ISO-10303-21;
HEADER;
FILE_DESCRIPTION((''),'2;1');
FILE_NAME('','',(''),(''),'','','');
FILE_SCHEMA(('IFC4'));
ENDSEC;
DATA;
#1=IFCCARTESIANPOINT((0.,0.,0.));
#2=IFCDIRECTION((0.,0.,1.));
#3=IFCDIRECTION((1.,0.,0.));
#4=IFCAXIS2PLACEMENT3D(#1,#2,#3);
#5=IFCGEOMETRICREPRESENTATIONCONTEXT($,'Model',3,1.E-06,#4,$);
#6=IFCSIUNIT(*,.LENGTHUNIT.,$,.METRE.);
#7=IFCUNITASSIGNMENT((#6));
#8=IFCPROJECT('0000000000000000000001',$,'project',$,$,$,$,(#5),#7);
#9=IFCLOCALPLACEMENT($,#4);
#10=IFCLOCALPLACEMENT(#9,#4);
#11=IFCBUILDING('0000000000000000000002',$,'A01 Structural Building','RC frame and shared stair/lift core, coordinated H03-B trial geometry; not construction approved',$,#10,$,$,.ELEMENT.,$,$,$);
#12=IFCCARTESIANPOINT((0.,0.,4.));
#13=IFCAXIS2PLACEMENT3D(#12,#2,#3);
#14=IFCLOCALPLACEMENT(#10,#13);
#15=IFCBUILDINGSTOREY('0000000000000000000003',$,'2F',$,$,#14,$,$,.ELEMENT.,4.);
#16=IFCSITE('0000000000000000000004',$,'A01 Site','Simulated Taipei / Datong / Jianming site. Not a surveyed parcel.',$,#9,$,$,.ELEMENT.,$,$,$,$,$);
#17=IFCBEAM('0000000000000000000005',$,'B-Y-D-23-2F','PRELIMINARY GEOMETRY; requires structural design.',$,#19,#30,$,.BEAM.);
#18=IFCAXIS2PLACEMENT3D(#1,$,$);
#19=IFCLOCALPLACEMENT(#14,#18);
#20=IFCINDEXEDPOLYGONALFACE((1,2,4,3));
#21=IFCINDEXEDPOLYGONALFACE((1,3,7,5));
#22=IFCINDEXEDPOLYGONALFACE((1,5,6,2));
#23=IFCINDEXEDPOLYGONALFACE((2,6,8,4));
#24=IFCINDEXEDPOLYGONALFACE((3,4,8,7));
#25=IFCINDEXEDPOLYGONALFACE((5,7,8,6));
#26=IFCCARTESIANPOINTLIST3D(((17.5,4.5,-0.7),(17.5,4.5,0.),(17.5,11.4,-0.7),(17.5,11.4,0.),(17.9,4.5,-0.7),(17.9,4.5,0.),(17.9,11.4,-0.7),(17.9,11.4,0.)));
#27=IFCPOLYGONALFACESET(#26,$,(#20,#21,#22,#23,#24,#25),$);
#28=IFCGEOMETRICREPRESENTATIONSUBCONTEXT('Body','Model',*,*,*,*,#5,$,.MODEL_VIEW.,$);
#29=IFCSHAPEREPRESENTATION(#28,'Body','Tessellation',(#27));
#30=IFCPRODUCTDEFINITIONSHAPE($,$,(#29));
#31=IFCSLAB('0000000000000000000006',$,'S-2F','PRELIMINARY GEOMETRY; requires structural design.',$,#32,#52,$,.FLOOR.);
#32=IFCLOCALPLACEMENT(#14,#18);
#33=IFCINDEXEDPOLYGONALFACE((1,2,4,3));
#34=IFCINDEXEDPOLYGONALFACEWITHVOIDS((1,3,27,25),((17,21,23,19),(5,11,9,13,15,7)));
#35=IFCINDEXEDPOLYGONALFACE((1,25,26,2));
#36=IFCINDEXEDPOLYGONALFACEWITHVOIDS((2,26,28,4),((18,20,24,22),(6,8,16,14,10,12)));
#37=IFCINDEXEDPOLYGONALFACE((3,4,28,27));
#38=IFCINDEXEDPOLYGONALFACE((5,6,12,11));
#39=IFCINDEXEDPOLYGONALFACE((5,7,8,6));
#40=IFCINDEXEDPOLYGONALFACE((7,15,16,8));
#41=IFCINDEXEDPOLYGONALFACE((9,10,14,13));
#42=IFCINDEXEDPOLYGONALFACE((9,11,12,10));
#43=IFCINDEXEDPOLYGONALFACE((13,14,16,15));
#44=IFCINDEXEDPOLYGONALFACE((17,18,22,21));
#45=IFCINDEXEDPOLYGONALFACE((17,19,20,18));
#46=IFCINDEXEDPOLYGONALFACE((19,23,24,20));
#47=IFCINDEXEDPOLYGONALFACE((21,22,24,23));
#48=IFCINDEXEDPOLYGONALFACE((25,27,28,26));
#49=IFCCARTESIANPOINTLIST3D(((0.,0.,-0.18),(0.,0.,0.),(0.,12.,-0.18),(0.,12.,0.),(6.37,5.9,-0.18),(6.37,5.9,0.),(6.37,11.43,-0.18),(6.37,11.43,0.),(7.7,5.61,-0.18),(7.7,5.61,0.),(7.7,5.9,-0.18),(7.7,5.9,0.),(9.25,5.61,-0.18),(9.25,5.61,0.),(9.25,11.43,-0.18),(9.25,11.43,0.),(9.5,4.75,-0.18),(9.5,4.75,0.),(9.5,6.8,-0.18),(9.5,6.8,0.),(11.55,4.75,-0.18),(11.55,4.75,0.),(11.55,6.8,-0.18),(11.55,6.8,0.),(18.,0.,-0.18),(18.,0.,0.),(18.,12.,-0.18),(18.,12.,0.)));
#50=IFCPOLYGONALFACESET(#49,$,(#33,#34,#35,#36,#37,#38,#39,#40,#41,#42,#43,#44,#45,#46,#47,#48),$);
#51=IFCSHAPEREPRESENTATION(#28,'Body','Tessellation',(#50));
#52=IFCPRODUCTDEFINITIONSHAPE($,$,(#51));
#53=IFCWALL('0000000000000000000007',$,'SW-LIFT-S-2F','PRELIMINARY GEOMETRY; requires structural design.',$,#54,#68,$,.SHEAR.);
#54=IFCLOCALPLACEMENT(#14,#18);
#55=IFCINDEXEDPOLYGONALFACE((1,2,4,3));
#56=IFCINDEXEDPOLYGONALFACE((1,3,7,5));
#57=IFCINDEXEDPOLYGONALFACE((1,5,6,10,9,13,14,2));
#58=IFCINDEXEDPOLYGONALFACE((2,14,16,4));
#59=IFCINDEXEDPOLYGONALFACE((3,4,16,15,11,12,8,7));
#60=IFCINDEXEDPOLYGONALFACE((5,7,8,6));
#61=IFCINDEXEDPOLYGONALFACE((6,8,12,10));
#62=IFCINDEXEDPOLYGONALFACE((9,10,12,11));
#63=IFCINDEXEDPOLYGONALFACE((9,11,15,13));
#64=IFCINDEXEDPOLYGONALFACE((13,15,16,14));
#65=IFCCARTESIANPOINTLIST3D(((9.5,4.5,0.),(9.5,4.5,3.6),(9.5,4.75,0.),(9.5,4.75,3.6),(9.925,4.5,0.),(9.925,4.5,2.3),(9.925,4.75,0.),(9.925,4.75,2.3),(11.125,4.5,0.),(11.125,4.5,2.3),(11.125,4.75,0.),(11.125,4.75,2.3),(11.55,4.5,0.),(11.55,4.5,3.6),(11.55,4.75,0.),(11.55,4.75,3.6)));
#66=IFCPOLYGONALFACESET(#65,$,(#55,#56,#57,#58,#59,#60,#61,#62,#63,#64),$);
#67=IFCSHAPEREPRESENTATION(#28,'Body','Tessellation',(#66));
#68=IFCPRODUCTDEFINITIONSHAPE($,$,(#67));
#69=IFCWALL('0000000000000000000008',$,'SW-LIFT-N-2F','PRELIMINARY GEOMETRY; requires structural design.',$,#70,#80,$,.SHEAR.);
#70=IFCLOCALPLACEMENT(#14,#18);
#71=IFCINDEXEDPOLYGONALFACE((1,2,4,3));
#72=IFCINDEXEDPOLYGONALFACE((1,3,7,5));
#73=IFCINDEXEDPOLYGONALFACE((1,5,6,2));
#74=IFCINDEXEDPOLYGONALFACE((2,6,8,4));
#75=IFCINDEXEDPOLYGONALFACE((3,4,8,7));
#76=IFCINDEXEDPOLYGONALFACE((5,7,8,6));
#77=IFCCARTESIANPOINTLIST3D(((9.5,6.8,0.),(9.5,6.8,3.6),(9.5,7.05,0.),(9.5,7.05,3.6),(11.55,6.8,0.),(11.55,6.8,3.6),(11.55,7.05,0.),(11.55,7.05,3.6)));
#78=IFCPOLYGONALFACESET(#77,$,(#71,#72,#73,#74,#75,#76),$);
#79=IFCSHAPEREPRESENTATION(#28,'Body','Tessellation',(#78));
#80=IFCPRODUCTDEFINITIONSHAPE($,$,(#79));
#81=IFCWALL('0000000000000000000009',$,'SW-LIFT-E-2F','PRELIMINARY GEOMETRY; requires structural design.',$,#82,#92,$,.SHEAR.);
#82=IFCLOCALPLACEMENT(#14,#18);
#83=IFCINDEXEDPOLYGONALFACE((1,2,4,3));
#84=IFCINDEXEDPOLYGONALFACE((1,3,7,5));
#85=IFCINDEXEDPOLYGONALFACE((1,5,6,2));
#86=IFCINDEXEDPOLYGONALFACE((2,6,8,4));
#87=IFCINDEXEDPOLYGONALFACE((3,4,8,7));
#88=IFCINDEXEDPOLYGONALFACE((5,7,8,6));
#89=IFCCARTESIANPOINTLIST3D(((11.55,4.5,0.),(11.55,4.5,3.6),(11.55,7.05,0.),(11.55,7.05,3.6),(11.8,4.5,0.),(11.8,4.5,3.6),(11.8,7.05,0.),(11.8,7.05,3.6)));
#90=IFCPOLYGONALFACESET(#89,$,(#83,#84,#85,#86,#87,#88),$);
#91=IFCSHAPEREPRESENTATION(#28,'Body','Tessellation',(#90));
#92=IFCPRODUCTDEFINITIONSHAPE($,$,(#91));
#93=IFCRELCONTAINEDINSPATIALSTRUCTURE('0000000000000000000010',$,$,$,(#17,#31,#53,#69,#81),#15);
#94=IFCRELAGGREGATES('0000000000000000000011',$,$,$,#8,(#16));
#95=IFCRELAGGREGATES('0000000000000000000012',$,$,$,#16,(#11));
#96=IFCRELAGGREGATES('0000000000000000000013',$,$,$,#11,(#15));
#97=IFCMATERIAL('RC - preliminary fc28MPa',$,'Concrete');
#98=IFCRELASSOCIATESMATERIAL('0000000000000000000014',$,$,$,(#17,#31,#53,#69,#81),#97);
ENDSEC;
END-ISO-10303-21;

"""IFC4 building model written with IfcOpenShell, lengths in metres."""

from ifc_helpers import new_model, si_unit, frame, origin_with_axes, place, context, subcontext, project, spatial, polyline, rectangle, outline, extrude, material, element, save


model = new_model("IFC4")

# Units and contexts
model_context = context("Model", 3, precision=1e-06, world=origin_with_axes())
body_context = subcontext(model_context, "Body", "Model", "MODEL_VIEW")
ifc_project = project(units=[si_unit("LENGTHUNIT", "METRE")], contexts=[model_context])

# Site, building, storey
site_placement = place(None, origin_with_axes())
site = spatial("IfcSite", under=ifc_project, at=site_placement, Name="A01 Site", Description="Simulated Taipei / Datong / Jianming site. Not a surveyed parcel.", CompositionType="ELEMENT")
building_placement = place(site_placement, origin_with_axes())
building = spatial("IfcBuilding", under=site, at=building_placement, Name="A01 Structural Building", Description="RC frame and shared stair/lift core, coordinated H03-B trial geometry; not construction approved", CompositionType="ELEMENT")
storey_placement = place(building_placement, frame((0.0, 0.0, 4.0), z_axis=(0.0, 0.0, 1.0), x_axis=(1.0, 0.0, 0.0)))
storey = spatial("IfcBuildingStorey", under=building, at=storey_placement, Name="2F", CompositionType="ELEMENT", Elevation=4.0)

# Shared definitions
ifc_material = material(Name="RC - preliminary fc28MPa", Category="Concrete")

# Beam
beam_1_placement = place(storey_placement, frame((17.7, 7.95, -0.7), z_axis=(0.0, 0.0, 1.0), x_axis=(1.0, 0.0, 0.0)))
element("IfcBeam", 1, at=beam_1_placement, inside=storey, material=ifc_material, Name="B-Y-D-23-2F", Description="PRELIMINARY GEOMETRY; requires structural design.", PredefinedType="BEAM", context=body_context, shape_type="SweptSolid", body=[
    extrude(rectangle(XDim=0.4, YDim=6.9), origin_with_axes(), (0.0, 0.0, 1.0), 0.7),
])

# Slab, openings
slab_placement = place(storey_placement, frame((9.0, 6.0, -0.18), z_axis=(0.0, 0.0, 1.0), x_axis=(1.0, 0.0, 0.0)))
slab = element("IfcSlab", 2, at=slab_placement, inside=storey, material=ifc_material, Name="S-2F", Description="PRELIMINARY GEOMETRY; requires structural design.", PredefinedType="FLOOR", context=body_context, shape_type="SweptSolid", body=[
    extrude(rectangle(XDim=18.0, YDim=12.0), origin_with_axes(), (0.0, 0.0, 1.0), 0.18),
])
opening_1_placement = place(storey_placement, frame((10.525, 5.775, -0.23), z_axis=(0.0, 0.0, 1.0), x_axis=(1.0, 0.0, 0.0)))
element("IfcOpeningElement", 3, at=opening_1_placement, cuts=slab, PredefinedType="OPENING", context=body_context, shape_type="SweptSolid", body=[
    extrude(rectangle(XDim=2.05, YDim=2.05), origin_with_axes(), (0.0, 0.0, 1.0), 0.28),
])
opening_2_placement = place(None, origin_with_axes())
element("IfcOpeningElement", 4, at=opening_2_placement, cuts=slab, PredefinedType="OPENING", context=body_context, shape_type="SweptSolid", body=[
    extrude(outline(polyline([(6.37, 5.9), (6.37, 11.43), (9.25, 11.43), (9.25, 5.61), (7.7, 5.61), (7.7, 5.9), (6.37, 5.9)])), frame((0.0, 0.0, 3.77), z_axis=(0.0, 0.0, 1.0), x_axis=(1.0, 0.0, 0.0)), (0.0, 0.0, 1.0), 0.28),
])

# Wall, opening
wall_1_placement = place(storey_placement, frame((10.525, 4.625, 0.0), z_axis=(0.0, 0.0, 1.0), x_axis=(1.0, 0.0, 0.0)))
wall_1 = element("IfcWall", 5, at=wall_1_placement, inside=storey, material=ifc_material, Name="SW-LIFT-S-2F", Description="PRELIMINARY GEOMETRY; requires structural design.", PredefinedType="SHEAR", context=body_context, shape_type="SweptSolid", body=[
    extrude(rectangle(XDim=2.05, YDim=0.25), origin_with_axes(), (0.0, 0.0, 1.0), 3.6),
])
opening_3_placement = place(storey_placement, frame((10.525, 4.625, 0.0), z_axis=(0.0, 0.0, 1.0), x_axis=(1.0, 0.0, 0.0)))
element("IfcOpeningElement", 6, at=opening_3_placement, cuts=wall_1, PredefinedType="OPENING", context=body_context, shape_type="SweptSolid", body=[
    extrude(rectangle(XDim=1.2, YDim=0.45), origin_with_axes(), (0.0, 0.0, 1.0), 2.3),
])

# Walls
wall_2_placement = place(storey_placement, frame((10.525, 6.925, 0.0), z_axis=(0.0, 0.0, 1.0), x_axis=(1.0, 0.0, 0.0)))
element("IfcWall", 7, at=wall_2_placement, inside=storey, material=ifc_material, Name="SW-LIFT-N-2F", Description="PRELIMINARY GEOMETRY; requires structural design.", PredefinedType="SHEAR", context=body_context, shape_type="SweptSolid", body=[
    extrude(rectangle(XDim=2.05, YDim=0.25), origin_with_axes(), (0.0, 0.0, 1.0), 3.6),
])
wall_3_placement = place(storey_placement, frame((11.675, 5.775, 0.0), z_axis=(0.0, 0.0, 1.0), x_axis=(1.0, 0.0, 0.0)))
element("IfcWall", 8, at=wall_3_placement, inside=storey, material=ifc_material, Name="SW-LIFT-E-2F", Description="PRELIMINARY GEOMETRY; requires structural design.", PredefinedType="SHEAR", context=body_context, shape_type="SweptSolid", body=[
    extrude(rectangle(XDim=0.25, YDim=2.55), origin_with_axes(), (0.0, 0.0, 1.0), 3.6),
])

save(model, "model.ifc")
